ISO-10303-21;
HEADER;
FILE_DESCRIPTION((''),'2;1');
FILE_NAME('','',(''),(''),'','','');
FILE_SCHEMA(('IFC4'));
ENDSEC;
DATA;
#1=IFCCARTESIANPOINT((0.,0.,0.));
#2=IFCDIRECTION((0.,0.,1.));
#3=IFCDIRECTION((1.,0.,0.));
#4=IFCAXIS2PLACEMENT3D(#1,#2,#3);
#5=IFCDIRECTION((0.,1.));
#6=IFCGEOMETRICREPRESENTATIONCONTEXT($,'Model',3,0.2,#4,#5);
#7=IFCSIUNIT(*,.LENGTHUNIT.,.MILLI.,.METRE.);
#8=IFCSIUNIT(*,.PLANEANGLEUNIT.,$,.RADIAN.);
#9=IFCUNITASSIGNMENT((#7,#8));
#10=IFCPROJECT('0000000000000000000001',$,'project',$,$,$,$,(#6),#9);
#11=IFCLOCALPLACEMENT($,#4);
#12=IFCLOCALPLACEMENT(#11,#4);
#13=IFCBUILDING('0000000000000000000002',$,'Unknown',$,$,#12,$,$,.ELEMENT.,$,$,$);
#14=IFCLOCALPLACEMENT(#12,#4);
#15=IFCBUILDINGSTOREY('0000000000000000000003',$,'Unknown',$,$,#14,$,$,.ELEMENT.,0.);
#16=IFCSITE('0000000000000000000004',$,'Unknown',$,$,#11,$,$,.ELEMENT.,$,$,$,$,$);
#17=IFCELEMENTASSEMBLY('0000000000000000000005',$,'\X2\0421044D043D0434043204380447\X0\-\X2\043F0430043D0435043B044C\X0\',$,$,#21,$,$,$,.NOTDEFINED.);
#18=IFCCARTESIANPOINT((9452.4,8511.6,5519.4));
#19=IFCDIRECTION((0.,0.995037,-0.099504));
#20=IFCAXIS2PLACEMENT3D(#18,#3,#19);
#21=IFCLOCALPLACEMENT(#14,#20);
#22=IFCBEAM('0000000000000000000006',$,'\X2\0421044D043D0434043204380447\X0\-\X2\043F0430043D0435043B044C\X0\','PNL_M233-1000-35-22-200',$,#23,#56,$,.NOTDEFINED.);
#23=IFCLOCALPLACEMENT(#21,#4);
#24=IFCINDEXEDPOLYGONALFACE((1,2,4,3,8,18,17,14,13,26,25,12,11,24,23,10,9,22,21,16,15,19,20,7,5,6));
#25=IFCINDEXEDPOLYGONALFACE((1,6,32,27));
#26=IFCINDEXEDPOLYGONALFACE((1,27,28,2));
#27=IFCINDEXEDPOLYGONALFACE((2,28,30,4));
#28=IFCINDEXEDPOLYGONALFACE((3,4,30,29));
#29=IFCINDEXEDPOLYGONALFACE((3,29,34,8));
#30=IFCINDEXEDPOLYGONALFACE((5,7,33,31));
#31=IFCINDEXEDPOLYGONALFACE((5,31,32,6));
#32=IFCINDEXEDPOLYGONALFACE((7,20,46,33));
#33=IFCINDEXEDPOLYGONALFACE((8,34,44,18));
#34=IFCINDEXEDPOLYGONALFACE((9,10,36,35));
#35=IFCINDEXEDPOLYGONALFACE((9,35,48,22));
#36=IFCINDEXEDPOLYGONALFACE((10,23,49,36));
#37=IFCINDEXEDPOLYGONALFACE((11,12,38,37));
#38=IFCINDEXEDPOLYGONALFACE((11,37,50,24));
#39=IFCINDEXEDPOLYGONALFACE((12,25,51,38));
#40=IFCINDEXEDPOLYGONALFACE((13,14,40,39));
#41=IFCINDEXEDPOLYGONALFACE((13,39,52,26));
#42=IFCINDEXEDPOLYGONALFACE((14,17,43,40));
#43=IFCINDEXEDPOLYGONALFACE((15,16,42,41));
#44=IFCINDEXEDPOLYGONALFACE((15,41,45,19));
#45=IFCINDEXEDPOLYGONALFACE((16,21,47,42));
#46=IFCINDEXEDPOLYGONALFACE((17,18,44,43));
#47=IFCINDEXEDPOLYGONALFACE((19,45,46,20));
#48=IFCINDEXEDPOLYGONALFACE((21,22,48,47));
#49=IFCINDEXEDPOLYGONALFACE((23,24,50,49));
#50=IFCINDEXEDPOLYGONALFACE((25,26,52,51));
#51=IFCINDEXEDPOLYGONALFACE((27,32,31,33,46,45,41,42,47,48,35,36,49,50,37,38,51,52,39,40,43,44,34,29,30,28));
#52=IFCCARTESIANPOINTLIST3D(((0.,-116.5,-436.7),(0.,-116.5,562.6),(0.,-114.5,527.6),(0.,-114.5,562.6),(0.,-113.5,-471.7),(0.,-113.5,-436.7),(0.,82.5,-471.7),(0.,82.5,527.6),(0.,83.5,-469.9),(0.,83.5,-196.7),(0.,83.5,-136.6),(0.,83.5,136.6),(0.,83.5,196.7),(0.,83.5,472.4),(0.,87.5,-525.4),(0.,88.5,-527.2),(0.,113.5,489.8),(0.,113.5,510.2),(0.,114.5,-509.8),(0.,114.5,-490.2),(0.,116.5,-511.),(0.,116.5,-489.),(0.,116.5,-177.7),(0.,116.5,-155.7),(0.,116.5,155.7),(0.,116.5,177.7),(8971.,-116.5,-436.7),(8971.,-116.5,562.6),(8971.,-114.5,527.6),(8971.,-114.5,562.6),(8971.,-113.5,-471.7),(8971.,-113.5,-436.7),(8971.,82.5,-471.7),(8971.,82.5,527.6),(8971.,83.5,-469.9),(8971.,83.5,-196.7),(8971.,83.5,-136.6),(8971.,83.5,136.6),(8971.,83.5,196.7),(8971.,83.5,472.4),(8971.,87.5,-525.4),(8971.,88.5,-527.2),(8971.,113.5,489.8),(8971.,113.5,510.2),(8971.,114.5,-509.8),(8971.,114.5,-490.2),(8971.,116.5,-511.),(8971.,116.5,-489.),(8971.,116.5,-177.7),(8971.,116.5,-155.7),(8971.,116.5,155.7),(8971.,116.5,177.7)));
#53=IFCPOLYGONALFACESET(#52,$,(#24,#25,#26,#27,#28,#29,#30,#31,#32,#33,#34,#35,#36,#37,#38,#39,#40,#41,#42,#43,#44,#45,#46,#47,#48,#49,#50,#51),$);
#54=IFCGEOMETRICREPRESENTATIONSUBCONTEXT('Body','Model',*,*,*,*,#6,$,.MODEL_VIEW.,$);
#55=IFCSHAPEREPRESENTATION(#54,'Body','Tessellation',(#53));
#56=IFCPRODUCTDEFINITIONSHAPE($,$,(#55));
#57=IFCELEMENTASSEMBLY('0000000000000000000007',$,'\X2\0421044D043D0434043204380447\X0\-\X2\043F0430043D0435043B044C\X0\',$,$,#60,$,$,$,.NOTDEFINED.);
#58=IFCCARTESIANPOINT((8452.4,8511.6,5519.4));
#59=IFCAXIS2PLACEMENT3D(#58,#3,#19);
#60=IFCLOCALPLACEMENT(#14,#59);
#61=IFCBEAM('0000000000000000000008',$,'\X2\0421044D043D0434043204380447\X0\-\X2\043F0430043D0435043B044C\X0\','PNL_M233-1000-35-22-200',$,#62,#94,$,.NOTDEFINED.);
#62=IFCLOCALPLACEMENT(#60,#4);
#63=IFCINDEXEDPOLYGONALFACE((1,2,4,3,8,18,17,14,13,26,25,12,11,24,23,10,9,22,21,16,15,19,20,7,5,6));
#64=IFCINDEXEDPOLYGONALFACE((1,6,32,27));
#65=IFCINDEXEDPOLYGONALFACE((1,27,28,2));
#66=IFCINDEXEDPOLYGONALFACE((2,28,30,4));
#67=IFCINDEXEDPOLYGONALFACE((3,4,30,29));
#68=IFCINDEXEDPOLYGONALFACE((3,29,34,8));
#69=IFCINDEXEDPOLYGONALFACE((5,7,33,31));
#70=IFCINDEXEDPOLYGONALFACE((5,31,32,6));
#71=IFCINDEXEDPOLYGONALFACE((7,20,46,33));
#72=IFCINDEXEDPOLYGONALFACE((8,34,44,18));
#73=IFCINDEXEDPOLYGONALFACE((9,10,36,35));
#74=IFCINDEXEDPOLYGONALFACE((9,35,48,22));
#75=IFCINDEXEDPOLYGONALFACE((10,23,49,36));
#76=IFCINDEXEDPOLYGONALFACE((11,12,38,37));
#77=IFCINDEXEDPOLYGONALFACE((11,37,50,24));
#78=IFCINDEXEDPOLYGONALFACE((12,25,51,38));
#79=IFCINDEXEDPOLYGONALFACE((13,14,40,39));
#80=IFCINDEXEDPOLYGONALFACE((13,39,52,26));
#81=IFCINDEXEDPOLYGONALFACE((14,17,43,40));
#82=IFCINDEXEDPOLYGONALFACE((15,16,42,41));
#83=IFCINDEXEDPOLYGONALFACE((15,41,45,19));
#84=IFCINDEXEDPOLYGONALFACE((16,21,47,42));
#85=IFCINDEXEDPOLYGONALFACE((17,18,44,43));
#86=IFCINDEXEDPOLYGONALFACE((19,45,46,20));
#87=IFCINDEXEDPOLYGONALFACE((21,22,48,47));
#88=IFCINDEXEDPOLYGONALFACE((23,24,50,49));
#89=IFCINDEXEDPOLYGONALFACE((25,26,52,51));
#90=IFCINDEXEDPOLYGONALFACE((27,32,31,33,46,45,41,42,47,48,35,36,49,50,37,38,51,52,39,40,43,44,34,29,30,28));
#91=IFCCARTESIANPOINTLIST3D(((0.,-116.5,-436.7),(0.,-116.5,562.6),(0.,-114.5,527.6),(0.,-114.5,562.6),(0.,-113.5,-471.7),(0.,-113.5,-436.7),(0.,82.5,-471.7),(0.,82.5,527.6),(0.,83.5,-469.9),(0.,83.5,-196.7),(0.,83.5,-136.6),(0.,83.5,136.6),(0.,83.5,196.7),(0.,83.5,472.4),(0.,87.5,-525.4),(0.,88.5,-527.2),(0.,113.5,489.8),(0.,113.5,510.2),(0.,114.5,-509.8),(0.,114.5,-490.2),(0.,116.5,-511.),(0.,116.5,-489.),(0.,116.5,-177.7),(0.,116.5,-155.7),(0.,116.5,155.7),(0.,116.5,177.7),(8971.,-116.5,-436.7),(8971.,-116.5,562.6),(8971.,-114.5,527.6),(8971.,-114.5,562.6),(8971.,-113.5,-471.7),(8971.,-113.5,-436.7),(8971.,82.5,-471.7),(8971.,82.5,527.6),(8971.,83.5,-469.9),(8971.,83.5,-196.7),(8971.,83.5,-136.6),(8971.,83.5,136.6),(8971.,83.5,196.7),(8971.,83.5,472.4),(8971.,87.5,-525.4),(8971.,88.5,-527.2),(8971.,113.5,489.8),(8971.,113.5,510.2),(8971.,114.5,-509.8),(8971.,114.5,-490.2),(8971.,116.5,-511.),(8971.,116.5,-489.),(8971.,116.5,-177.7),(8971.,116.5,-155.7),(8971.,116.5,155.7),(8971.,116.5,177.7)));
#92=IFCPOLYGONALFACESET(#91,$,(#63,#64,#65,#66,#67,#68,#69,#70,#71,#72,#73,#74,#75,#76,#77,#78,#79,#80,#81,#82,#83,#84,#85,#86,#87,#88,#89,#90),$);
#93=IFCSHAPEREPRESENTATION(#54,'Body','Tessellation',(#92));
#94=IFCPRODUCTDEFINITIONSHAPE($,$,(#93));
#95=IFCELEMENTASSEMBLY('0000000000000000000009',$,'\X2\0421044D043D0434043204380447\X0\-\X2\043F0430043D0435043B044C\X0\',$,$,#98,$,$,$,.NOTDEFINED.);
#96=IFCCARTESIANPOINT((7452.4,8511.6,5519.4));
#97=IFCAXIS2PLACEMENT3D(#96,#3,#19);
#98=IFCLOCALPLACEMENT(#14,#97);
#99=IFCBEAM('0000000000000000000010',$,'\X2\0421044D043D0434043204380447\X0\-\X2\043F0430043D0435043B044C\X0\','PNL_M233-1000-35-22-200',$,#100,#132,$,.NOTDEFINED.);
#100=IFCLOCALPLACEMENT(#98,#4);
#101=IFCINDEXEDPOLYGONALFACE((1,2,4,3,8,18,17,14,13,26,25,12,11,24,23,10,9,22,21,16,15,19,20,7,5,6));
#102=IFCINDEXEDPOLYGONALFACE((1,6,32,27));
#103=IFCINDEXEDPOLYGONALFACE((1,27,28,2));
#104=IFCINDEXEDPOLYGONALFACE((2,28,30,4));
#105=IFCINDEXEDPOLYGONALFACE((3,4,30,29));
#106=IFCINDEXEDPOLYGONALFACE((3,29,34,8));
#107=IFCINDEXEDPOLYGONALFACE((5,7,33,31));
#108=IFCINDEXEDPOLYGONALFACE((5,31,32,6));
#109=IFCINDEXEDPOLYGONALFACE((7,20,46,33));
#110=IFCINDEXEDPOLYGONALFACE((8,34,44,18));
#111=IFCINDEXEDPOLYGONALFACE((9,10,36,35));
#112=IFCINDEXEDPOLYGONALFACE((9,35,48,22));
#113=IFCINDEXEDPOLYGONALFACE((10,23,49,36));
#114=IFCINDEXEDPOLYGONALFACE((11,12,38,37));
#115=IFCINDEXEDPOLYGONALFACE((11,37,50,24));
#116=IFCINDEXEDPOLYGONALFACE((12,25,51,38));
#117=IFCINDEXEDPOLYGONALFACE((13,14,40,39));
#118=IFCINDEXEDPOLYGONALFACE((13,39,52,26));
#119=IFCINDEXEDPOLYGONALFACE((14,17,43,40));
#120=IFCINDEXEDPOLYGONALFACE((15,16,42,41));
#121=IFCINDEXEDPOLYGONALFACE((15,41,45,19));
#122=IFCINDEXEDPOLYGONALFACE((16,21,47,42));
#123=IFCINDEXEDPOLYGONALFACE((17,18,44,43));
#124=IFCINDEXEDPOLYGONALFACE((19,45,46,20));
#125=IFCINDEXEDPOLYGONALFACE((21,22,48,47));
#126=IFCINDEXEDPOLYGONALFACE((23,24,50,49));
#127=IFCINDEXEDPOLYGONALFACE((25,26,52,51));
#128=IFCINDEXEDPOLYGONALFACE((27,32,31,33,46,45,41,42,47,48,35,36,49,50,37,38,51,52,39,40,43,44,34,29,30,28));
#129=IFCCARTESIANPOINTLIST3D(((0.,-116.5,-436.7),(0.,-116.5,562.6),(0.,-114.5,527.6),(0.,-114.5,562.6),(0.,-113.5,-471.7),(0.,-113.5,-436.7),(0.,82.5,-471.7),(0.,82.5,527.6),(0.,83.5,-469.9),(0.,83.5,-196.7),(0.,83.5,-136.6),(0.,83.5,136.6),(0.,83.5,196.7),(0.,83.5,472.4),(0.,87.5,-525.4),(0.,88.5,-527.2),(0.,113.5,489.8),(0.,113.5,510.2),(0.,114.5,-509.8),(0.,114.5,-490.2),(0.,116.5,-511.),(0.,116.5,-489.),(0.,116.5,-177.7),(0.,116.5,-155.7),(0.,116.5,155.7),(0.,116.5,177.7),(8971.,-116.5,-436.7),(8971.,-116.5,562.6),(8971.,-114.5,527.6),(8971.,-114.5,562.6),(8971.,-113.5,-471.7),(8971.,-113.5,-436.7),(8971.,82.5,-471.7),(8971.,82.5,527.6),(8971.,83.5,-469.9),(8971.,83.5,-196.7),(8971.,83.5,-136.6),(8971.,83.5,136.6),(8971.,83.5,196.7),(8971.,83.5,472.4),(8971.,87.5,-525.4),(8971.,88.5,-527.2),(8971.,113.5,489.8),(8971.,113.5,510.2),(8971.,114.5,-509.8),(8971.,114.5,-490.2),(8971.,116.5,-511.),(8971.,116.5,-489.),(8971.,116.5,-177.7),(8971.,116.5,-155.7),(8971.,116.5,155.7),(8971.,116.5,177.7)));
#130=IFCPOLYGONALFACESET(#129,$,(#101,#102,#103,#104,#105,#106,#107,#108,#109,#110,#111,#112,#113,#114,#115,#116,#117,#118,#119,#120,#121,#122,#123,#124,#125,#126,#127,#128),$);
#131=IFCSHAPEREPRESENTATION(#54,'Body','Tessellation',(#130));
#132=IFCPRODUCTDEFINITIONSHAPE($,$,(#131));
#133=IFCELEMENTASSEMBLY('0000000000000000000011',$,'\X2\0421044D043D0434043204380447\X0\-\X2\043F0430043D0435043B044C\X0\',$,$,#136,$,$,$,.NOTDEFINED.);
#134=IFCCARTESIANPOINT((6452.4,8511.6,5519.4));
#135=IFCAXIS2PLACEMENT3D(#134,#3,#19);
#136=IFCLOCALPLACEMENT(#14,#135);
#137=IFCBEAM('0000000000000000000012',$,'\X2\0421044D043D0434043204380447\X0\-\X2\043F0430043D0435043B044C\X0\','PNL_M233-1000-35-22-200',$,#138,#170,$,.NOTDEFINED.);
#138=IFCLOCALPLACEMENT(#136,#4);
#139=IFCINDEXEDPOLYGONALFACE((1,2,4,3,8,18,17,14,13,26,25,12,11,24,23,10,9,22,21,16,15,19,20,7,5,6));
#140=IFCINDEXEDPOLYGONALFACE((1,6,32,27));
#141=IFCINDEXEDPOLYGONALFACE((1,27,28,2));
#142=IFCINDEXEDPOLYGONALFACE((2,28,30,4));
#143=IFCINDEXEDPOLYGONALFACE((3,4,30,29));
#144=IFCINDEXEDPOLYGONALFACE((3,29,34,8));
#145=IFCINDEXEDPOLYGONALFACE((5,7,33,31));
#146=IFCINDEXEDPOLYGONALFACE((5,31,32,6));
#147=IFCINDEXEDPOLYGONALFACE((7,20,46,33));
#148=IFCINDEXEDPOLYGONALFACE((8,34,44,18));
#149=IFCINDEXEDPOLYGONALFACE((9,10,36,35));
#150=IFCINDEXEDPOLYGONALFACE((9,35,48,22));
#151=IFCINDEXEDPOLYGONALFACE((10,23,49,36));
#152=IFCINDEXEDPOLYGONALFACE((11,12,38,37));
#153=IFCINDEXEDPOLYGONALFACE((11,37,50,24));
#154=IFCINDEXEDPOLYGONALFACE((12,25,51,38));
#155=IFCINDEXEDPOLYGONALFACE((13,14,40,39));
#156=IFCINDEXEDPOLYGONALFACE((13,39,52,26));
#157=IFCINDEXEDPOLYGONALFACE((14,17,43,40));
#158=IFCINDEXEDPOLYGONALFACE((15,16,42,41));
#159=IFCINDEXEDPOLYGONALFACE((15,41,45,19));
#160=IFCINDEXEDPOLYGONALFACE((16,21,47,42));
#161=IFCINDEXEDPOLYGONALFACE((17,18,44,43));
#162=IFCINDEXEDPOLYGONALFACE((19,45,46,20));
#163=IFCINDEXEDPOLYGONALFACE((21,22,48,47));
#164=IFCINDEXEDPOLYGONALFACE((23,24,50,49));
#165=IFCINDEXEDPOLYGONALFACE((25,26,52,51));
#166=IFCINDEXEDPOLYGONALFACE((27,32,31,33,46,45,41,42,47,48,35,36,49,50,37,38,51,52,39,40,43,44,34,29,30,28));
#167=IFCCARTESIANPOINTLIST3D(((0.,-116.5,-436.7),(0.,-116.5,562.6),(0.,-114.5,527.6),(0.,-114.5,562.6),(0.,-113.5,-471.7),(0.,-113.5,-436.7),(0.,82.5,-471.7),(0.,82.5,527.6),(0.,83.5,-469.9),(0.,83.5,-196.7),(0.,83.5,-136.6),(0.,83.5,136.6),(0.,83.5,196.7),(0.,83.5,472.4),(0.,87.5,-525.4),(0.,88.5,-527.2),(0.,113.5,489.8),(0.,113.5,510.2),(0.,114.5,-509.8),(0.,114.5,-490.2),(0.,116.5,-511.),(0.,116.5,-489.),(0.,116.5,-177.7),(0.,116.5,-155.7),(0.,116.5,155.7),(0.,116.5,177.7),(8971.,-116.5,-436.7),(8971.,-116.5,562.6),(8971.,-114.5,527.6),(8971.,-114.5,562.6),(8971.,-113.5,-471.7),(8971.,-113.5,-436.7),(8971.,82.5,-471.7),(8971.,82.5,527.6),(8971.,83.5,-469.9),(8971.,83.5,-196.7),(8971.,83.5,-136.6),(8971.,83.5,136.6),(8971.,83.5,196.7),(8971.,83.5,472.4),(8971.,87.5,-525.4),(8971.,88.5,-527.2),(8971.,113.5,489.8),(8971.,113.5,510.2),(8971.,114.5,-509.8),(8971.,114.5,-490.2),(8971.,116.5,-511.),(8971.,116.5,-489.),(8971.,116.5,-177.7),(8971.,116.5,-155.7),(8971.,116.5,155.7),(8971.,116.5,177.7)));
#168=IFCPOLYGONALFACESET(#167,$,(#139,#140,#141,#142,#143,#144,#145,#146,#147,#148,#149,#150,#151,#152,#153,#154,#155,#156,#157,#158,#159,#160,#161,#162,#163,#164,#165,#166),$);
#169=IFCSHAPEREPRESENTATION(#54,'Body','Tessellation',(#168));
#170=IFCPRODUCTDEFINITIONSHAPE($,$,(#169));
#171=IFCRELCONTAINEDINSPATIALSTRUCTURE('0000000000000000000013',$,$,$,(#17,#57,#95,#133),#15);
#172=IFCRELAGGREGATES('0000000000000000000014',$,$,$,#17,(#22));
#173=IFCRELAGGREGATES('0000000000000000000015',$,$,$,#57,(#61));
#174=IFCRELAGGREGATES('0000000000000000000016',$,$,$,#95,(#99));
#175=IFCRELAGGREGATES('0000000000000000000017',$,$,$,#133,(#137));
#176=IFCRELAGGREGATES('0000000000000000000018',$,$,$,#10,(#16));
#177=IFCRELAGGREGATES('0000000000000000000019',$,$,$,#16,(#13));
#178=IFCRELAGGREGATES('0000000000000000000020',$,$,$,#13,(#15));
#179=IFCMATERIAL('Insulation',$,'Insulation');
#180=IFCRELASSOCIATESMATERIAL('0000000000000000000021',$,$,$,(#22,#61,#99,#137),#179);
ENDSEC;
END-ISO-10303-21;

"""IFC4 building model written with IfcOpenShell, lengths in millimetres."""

from ifc_helpers import new_model, si_unit, direction, frame, origin_with_axes, place, context, subcontext, project, spatial, line, indexed_curve, outline, extrude, material, element, aggregate, save


model = new_model("IFC4")

# Units and contexts
model_context = context("Model", 3, precision=0.2, world=origin_with_axes(), true_north=direction((0.0, 1.0)))
body_context = subcontext(model_context, "Body", "Model", "MODEL_VIEW")
ifc_project = project(units=[si_unit("LENGTHUNIT", "METRE", prefix="MILLI"), si_unit("PLANEANGLEUNIT", "RADIAN")], contexts=[model_context])

# Site, building, storey
site_placement = place(None, origin_with_axes())
site = spatial("IfcSite", under=ifc_project, at=site_placement, Name="Unknown", CompositionType="ELEMENT")
building_placement = place(site_placement, origin_with_axes())
building = spatial("IfcBuilding", under=site, at=building_placement, Name="Unknown", CompositionType="ELEMENT")
storey_placement = place(building_placement, origin_with_axes())
storey = spatial("IfcBuildingStorey", under=building, at=storey_placement, Name="Unknown", CompositionType="ELEMENT", Elevation=0.0)

# Element assemblies, beams
assembly_1_placement = place(storey_placement, frame((9452.4, 8511.6, 5519.4), z_axis=(1.0, 0.0, 0.0), x_axis=(0.0, 0.995037, -0.099504)))
assembly_1 = element("IfcElementAssembly", 1, at=assembly_1_placement, inside=storey, Name="Сэндвич-панель", PredefinedType="NOTDEFINED")
ifc_material_1 = material(Name="Insulation", Category="Insulation")
beam_1_placement = place(assembly_1_placement, origin_with_axes())
beam_1 = element("IfcBeam", 2, at=beam_1_placement, material=ifc_material_1, Name="Сэндвич-панель", Description="PNL_M233-1000-35-22-200", PredefinedType="NOTDEFINED", context=body_context, shape_type="SolidModel", body=[
    extrude(outline(indexed_curve([(-509.8, 114.5), (-490.2, 114.5), (-471.7, 82.5), (-471.7, -113.5), (-436.7, -113.5), (-436.7, -116.5), (562.6, -116.5), (562.6, -114.5), (527.6, -114.5), (527.6, 82.5), (510.2, 113.5), (489.8, 113.5), (472.4, 83.5), (196.7, 83.5), (177.7, 116.5), (155.7, 116.5), (136.6, 83.5), (-136.6, 83.5), (-155.7, 116.5), (-177.7, 116.5), (-196.7, 83.5), (-469.9, 83.5), (-489.0, 116.5), (-511.0, 116.5), (-527.2, 88.5), (-525.4, 87.5)], segments=[line(1, 2, 3, 4, 5, 6, 7, 8, 9, 10, 11, 12, 13, 14, 15, 16, 17, 18, 19, 20, 21, 22, 23, 24, 25, 26, 1)])), frame((0.0, 0.0, 0.0), z_axis=(-1.0, 0.0, 0.0), x_axis=(0.0, 0.0, 1.0)), (0.0, 0.0, -1.0), 8971.0),
])
aggregate(assembly_1, [beam_1])
assembly_2_placement = place(storey_placement, frame((8452.4, 8511.6, 5519.4), z_axis=(1.0, 0.0, 0.0), x_axis=(0.0, 0.995037, -0.099504)))
assembly_2 = element("IfcElementAssembly", 3, at=assembly_2_placement, inside=storey, Name="Сэндвич-панель", PredefinedType="NOTDEFINED")
beam_2_placement = place(assembly_2_placement, origin_with_axes())
beam_2 = element("IfcBeam", 4, at=beam_2_placement, material=ifc_material_1, Name="Сэндвич-панель", Description="PNL_M233-1000-35-22-200", PredefinedType="NOTDEFINED", context=body_context, shape_type="SolidModel", body=[
    extrude(outline(indexed_curve([(-509.8, 114.5), (-490.2, 114.5), (-471.7, 82.5), (-471.7, -113.5), (-436.7, -113.5), (-436.7, -116.5), (562.6, -116.5), (562.6, -114.5), (527.6, -114.5), (527.6, 82.5), (510.2, 113.5), (489.8, 113.5), (472.4, 83.5), (196.7, 83.5), (177.7, 116.5), (155.7, 116.5), (136.6, 83.5), (-136.6, 83.5), (-155.7, 116.5), (-177.7, 116.5), (-196.7, 83.5), (-469.9, 83.5), (-489.0, 116.5), (-511.0, 116.5), (-527.2, 88.5), (-525.4, 87.5)], segments=[line(1, 2, 3, 4, 5, 6, 7, 8, 9, 10, 11, 12, 13, 14, 15, 16, 17, 18, 19, 20, 21, 22, 23, 24, 25, 26, 1)])), frame((0.0, 0.0, 0.0), z_axis=(-1.0, 0.0, 0.0), x_axis=(0.0, 0.0, 1.0)), (0.0, 0.0, -1.0), 8971.0),
])
aggregate(assembly_2, [beam_2])
assembly_3_placement = place(storey_placement, frame((7452.4, 8511.6, 5519.4), z_axis=(1.0, 0.0, 0.0), x_axis=(0.0, 0.995037, -0.099504)))
assembly_3 = element("IfcElementAssembly", 5, at=assembly_3_placement, inside=storey, Name="Сэндвич-панель", PredefinedType="NOTDEFINED")
beam_3_placement = place(assembly_3_placement, origin_with_axes())
beam_3 = element("IfcBeam", 6, at=beam_3_placement, material=ifc_material_1, Name="Сэндвич-панель", Description="PNL_M233-1000-35-22-200", PredefinedType="NOTDEFINED", context=body_context, shape_type="SolidModel", body=[
    extrude(outline(indexed_curve([(-509.8, 114.5), (-490.2, 114.5), (-471.7, 82.5), (-471.7, -113.5), (-436.7, -113.5), (-436.7, -116.5), (562.6, -116.5), (562.6, -114.5), (527.6, -114.5), (527.6, 82.5), (510.2, 113.5), (489.8, 113.5), (472.4, 83.5), (196.7, 83.5), (177.7, 116.5), (155.7, 116.5), (136.6, 83.5), (-136.6, 83.5), (-155.7, 116.5), (-177.7, 116.5), (-196.7, 83.5), (-469.9, 83.5), (-489.0, 116.5), (-511.0, 116.5), (-527.2, 88.5), (-525.4, 87.5)], segments=[line(1, 2, 3, 4, 5, 6, 7, 8, 9, 10, 11, 12, 13, 14, 15, 16, 17, 18, 19, 20, 21, 22, 23, 24, 25, 26, 1)])), frame((0.0, 0.0, 0.0), z_axis=(-1.0, 0.0, 0.0), x_axis=(0.0, 0.0, 1.0)), (0.0, 0.0, -1.0), 8971.0),
])
aggregate(assembly_3, [beam_3])
assembly_4_placement = place(storey_placement, frame((6452.4, 8511.6, 5519.4), z_axis=(1.0, 0.0, 0.0), x_axis=(0.0, 0.995037, -0.099504)))
assembly_4 = element("IfcElementAssembly", 7, at=assembly_4_placement, inside=storey, Name="Сэндвич-панель", PredefinedType="NOTDEFINED")
beam_4_placement = place(assembly_4_placement, origin_with_axes())
beam_4 = element("IfcBeam", 8, at=beam_4_placement, material=ifc_material_1, Name="Сэндвич-панель", Description="PNL_M233-1000-35-22-200", PredefinedType="NOTDEFINED", context=body_context, shape_type="SolidModel", body=[
    extrude(outline(indexed_curve([(-509.8, 114.5), (-490.2, 114.5), (-471.7, 82.5), (-471.7, -113.5), (-436.7, -113.5), (-436.7, -116.5), (562.6, -116.5), (562.6, -114.5), (527.6, -114.5), (527.6, 82.5), (510.2, 113.5), (489.8, 113.5), (472.4, 83.5), (196.7, 83.5), (177.7, 116.5), (155.7, 116.5), (136.6, 83.5), (-136.6, 83.5), (-155.7, 116.5), (-177.7, 116.5), (-196.7, 83.5), (-469.9, 83.5), (-489.0, 116.5), (-511.0, 116.5), (-527.2, 88.5), (-525.4, 87.5)], segments=[line(1, 2, 3, 4, 5, 6, 7, 8, 9, 10, 11, 12, 13, 14, 15, 16, 17, 18, 19, 20, 21, 22, 23, 24, 25, 26, 1)])), frame((0.0, 0.0, 0.0), z_axis=(-1.0, 0.0, 0.0), x_axis=(0.0, 0.0, 1.0)), (0.0, 0.0, -1.0), 8971.0),
])
aggregate(assembly_4, [beam_4])

save(model, "model.ifc")
